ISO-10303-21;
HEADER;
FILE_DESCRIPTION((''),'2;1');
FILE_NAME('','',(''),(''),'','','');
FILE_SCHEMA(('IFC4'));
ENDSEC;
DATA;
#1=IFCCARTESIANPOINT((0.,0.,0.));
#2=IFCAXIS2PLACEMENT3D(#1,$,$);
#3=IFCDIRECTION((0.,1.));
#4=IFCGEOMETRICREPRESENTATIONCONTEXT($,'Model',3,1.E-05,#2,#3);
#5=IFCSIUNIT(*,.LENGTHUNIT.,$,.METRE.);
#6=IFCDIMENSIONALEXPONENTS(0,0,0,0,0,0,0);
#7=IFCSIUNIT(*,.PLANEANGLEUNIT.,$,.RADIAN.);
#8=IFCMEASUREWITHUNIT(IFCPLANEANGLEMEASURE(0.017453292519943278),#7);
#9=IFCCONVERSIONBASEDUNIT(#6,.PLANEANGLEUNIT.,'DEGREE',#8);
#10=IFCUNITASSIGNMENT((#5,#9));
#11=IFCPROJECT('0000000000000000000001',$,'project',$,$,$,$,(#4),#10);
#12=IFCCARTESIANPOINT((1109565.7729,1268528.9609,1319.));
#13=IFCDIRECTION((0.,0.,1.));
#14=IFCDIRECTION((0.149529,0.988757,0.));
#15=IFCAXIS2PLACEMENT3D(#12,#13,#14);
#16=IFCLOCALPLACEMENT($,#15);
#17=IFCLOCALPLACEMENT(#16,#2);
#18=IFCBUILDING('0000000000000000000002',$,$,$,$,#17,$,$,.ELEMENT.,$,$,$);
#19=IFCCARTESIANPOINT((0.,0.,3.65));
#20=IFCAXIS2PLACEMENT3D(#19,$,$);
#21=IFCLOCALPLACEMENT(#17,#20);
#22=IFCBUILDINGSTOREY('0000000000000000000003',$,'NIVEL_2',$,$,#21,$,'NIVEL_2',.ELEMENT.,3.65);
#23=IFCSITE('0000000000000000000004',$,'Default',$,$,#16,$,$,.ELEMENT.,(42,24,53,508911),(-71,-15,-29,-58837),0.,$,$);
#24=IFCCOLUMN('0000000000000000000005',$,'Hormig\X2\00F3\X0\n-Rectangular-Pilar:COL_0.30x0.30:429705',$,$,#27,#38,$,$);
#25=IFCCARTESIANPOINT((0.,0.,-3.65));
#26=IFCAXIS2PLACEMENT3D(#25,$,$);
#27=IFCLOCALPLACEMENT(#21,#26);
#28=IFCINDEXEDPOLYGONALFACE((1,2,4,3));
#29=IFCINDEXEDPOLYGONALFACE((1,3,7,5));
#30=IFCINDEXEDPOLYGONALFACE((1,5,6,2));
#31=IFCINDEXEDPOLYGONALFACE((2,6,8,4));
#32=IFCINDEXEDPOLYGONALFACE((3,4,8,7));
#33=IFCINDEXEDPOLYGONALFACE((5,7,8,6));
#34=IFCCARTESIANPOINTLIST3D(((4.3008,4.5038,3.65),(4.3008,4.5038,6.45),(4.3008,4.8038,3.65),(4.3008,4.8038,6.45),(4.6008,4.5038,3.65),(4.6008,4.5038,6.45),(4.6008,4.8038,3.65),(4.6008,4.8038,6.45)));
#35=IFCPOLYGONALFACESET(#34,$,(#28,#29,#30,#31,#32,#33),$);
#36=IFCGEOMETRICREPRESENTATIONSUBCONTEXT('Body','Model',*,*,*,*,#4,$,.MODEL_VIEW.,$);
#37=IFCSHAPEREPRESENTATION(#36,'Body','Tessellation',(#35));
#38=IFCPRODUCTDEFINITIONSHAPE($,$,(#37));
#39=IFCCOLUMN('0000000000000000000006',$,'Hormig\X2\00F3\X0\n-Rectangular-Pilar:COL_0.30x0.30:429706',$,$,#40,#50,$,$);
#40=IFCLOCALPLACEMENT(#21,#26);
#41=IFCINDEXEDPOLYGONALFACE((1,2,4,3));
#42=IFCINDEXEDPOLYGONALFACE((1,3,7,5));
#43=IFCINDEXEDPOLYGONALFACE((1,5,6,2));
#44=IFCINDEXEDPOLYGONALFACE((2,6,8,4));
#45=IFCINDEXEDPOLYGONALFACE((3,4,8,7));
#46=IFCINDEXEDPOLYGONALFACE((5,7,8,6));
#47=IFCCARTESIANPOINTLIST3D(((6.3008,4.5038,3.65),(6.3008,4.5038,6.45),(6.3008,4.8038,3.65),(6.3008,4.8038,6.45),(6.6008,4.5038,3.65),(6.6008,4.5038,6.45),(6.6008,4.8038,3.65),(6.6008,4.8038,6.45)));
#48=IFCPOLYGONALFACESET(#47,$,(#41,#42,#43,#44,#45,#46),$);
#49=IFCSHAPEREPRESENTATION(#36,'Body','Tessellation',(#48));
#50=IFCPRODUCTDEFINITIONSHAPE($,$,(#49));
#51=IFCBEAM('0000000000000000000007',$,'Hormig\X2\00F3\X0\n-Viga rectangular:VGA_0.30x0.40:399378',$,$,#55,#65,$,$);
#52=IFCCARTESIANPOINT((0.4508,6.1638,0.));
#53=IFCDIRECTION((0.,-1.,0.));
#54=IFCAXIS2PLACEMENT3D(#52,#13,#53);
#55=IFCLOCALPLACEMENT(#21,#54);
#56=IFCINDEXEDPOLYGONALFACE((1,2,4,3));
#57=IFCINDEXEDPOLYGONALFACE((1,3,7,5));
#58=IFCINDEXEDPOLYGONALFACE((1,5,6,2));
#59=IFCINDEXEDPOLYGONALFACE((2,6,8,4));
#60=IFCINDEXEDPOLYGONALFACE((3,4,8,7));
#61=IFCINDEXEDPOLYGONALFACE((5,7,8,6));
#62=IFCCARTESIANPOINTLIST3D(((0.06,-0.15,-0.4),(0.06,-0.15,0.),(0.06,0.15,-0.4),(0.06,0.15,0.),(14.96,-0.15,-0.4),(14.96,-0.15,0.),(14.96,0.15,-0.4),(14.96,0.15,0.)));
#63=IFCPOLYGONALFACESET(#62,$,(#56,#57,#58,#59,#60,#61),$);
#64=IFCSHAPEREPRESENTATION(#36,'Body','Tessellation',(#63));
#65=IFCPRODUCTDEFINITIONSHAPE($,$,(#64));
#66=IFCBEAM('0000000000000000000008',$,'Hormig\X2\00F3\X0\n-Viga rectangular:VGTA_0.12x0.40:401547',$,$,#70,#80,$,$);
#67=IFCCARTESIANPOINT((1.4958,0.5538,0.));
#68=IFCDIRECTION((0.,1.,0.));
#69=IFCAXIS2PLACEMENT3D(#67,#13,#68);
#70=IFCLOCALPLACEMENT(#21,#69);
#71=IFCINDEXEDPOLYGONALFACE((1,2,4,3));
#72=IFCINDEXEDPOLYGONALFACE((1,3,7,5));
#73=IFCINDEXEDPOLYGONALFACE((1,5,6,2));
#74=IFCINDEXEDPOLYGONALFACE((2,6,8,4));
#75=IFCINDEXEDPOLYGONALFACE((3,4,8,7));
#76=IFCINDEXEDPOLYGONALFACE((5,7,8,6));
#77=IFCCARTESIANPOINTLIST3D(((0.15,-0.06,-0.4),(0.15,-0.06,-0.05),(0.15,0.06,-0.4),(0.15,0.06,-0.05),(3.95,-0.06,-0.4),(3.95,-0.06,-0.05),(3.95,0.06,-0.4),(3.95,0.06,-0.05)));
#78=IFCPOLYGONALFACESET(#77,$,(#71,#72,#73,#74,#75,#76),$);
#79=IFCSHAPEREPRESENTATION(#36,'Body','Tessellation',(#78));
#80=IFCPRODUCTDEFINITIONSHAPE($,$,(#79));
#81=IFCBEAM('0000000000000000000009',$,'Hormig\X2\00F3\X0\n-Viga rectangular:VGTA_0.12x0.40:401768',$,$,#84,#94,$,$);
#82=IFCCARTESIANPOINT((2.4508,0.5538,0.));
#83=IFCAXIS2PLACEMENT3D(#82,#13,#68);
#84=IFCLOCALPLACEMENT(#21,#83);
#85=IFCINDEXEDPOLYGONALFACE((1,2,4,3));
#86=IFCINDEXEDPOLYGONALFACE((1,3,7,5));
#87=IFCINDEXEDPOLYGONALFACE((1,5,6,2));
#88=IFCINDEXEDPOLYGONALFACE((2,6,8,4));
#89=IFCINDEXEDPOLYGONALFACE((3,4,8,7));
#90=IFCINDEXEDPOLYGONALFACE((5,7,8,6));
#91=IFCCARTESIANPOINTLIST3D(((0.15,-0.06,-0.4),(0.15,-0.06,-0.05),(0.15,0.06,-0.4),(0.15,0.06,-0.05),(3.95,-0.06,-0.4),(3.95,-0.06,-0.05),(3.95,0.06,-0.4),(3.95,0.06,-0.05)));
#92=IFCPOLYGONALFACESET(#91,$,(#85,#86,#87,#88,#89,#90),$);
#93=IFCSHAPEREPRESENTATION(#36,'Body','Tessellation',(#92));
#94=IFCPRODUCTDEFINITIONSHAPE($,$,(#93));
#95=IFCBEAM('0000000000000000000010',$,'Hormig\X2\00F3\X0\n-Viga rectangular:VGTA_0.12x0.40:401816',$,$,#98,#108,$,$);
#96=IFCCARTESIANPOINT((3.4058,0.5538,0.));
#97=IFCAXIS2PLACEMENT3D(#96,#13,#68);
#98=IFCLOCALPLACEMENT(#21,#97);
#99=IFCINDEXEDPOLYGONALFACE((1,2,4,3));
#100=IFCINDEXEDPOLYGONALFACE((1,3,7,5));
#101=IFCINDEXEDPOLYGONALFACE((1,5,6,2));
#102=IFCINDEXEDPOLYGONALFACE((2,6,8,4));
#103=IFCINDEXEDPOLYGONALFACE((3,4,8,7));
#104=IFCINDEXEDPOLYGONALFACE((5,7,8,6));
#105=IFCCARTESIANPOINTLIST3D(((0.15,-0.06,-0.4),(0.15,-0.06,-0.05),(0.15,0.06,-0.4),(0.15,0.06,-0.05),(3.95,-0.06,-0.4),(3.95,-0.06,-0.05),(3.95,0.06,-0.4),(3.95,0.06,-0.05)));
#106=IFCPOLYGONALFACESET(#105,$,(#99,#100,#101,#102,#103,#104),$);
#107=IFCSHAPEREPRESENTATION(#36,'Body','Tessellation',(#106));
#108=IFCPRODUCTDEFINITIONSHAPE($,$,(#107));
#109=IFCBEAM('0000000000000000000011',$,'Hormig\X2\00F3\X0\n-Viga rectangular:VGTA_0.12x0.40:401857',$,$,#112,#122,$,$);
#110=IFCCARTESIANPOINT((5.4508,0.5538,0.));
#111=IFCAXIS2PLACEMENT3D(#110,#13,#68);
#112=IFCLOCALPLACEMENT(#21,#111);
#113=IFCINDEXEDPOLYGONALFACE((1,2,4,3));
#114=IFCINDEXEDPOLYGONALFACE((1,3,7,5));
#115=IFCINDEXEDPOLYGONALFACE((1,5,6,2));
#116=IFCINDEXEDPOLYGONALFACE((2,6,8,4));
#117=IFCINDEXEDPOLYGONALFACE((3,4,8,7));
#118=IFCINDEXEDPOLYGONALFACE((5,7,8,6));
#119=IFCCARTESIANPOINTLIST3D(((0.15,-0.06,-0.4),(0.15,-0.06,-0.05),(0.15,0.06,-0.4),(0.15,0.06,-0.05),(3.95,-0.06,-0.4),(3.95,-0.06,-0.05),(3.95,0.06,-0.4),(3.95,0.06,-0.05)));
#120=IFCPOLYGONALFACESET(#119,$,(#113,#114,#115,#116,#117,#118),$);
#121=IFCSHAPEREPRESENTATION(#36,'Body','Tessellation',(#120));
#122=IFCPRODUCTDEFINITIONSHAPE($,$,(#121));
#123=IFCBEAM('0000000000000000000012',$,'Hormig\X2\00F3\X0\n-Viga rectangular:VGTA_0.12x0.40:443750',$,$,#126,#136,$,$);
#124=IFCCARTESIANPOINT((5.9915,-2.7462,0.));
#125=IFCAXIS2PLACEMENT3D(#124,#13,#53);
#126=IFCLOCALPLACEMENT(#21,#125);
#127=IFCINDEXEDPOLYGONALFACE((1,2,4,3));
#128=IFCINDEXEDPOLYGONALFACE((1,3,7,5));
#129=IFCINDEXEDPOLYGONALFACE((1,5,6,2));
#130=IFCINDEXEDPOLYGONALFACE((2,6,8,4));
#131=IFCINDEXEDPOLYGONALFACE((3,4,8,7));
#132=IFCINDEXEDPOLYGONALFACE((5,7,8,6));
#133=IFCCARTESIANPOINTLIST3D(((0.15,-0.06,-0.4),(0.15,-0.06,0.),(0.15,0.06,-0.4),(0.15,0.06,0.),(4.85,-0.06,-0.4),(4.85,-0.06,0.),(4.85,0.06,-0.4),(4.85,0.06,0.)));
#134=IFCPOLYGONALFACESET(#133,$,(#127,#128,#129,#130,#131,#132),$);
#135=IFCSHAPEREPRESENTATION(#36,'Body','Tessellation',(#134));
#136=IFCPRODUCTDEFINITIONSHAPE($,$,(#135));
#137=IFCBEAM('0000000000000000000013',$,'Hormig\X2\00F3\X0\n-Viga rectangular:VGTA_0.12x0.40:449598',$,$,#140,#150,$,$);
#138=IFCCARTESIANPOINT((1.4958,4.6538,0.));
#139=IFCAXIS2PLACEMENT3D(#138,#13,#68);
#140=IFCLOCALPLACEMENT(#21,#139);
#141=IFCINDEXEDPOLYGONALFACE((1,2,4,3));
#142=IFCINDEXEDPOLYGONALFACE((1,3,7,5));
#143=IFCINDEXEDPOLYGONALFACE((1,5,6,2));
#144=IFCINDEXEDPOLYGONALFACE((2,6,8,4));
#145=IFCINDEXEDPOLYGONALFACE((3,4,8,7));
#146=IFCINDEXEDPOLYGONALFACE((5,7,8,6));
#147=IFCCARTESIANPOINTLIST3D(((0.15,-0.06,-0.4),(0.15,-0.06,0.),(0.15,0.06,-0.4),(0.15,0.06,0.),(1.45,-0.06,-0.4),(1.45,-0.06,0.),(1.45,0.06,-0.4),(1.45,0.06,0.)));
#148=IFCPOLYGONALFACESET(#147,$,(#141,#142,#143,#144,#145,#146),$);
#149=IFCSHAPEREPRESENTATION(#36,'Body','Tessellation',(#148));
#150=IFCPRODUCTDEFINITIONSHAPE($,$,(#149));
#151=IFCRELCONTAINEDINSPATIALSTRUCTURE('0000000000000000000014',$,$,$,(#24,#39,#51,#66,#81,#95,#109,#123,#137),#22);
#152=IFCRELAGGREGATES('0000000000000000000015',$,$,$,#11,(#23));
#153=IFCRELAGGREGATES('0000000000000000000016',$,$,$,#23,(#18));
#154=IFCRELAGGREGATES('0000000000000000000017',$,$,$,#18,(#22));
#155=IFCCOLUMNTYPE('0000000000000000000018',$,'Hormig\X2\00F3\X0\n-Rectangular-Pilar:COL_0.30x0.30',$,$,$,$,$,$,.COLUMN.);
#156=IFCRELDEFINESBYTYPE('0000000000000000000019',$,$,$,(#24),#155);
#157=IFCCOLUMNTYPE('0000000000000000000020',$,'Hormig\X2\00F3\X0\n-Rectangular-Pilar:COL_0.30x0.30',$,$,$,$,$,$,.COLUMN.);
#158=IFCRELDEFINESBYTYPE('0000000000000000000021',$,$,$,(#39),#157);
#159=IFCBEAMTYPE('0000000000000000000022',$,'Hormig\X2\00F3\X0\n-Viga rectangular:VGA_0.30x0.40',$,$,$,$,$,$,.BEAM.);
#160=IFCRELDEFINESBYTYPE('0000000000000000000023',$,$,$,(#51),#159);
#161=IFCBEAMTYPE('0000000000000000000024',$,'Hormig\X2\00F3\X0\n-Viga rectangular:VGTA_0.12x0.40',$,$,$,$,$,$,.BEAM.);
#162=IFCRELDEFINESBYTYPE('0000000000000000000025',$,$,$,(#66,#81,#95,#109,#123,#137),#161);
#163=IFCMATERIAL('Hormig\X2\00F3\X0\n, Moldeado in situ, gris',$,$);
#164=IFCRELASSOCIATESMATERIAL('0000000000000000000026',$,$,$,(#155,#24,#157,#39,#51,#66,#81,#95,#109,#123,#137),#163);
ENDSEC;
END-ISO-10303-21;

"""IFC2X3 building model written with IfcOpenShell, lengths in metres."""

from ifc_helpers import new_model, entity, si_unit, converted_unit, direction, frame, frame_2d, origin, origin_2d_with_axis, place, context, subcontext, project, spatial, rectangle, extrude, source, transform, mapped, material, type_object, type_shapes, element, save


model = new_model("IFC2X3")

# Units and contexts
model_context = context("Model", 3, precision=1e-05, world=origin(), true_north=direction((0.0, 1.0)))
body_context = subcontext(model_context, "Body", "Model", "MODEL_VIEW")
ifc_project = project(units=[si_unit("LENGTHUNIT", "METRE"), converted_unit("PLANEANGLEUNIT", "DEGREE", entity("IfcPlaneAngleMeasure", 0.017453292519943278), si_unit("PLANEANGLEUNIT", "RADIAN"), dimensions=[0, 0, 0, 0, 0, 0, 0])], contexts=[model_context])

# Site, building, storey
site_placement = place(None, frame((1109565.7729, 1268528.9609, 1319.0), z_axis=(0.0, 0.0, 1.0), x_axis=(0.149529, 0.988757, 0.0)))
site = spatial("IfcSite", under=ifc_project, at=site_placement, Name="Default", CompositionType="ELEMENT", RefLatitude=(42, 24, 53, 508911), RefLongitude=(-71, -15, -29, -58837), RefElevation=0.0)
building_placement = place(site_placement, origin())
building = spatial("IfcBuilding", under=site, at=building_placement, CompositionType="ELEMENT")
storey_placement = place(building_placement, frame((0.0, 0.0, 3.65)))
storey = spatial("IfcBuildingStorey", under=building, at=storey_placement, Name="NIVEL_2", LongName="NIVEL_2", CompositionType="ELEMENT", Elevation=3.65)

# Columns
ifc_material_1 = material(Name="Hormigón, Moldeado in situ, gris")
column_type_1 = type_object("IfcColumnType", Name="Hormigón-Rectangular-Pilar:COL_0.30x0.30", PredefinedType="COLUMN", material=ifc_material_1)
shared_shape_1 = source(origin(), body_context, "Body", "SweptSolid", [
    extrude(rectangle(XDim=0.3, YDim=0.3, at=origin_2d_with_axis()), frame((4.4508, 4.6538, 3.65)), (0.0, 0.0, 1.0), 2.8),
])
type_shapes(column_type_1, [shared_shape_1])
column_1_placement = place(storey_placement, frame((0.0, 0.0, -3.65)))
element("IfcColumn", 1, at=column_1_placement, inside=storey, type_object=column_type_1, material=ifc_material_1, Name="Hormigón-Rectangular-Pilar:COL_0.30x0.30:429705", context=body_context, shape_type="MappedRepresentation", body=[
    mapped(shared_shape_1, transform((0.0, 0.0, 0.0), scale=1.0)),
])
column_type_2 = type_object("IfcColumnType", Name="Hormigón-Rectangular-Pilar:COL_0.30x0.30", PredefinedType="COLUMN", material=ifc_material_1)
shared_shape_2 = source(origin(), body_context, "Body", "SweptSolid", [
    extrude(rectangle(XDim=0.3, YDim=0.3, at=frame_2d((0.0, 0.0), x_axis=(1.0, 0.0))), frame((6.4508, 4.6538, 3.65)), (0.0, 0.0, 1.0), 2.8),
])
type_shapes(column_type_2, [shared_shape_2])
column_2_placement = place(storey_placement, frame((0.0, 0.0, -3.65)))
element("IfcColumn", 2, at=column_2_placement, inside=storey, type_object=column_type_2, material=ifc_material_1, Name="Hormigón-Rectangular-Pilar:COL_0.30x0.30:429706", context=body_context, shape_type="MappedRepresentation", body=[
    mapped(shared_shape_2, transform((0.0, 0.0, 0.0), scale=1.0)),
])

# Beams
beam_type_1 = type_object("IfcBeamType", Name="Hormigón-Viga rectangular:VGA_0.30x0.40", PredefinedType="BEAM")
beam_1_placement = place(storey_placement, frame((0.4508, 6.1638, 0.0), z_axis=(0.0, 0.0, 1.0), x_axis=(0.0, -1.0, 0.0)))
element("IfcBeam", 3, at=beam_1_placement, inside=storey, type_object=beam_type_1, material=ifc_material_1, Name="Hormigón-Viga rectangular:VGA_0.30x0.40:399378", context=body_context, shape_type="SweptSolid", body=[
    extrude(rectangle(XDim=0.4, YDim=0.3, at=frame_2d((0.0, 0.0), x_axis=(1.0, 0.0))), frame((0.06, 0.0, -0.2), z_axis=(1.0, 0.0, 0.0), x_axis=(0.0, 0.0, -1.0)), (0.0, 0.0, 1.0), 14.9),
])
beam_type_2 = type_object("IfcBeamType", Name="Hormigón-Viga rectangular:VGTA_0.12x0.40", PredefinedType="BEAM")
beam_2_placement = place(storey_placement, frame((1.4958, 0.5538, 0.0), z_axis=(0.0, 0.0, 1.0), x_axis=(0.0, 1.0, 0.0)))
element("IfcBeam", 4, at=beam_2_placement, inside=storey, type_object=beam_type_2, material=ifc_material_1, Name="Hormigón-Viga rectangular:VGTA_0.12x0.40:401547", context=body_context, shape_type="SweptSolid", body=[
    extrude(rectangle(XDim=0.35, YDim=0.12, at=frame_2d((0.0, 0.0), x_axis=(1.0, 0.0))), frame((0.15, 0.0, -0.225), z_axis=(1.0, 0.0, 0.0), x_axis=(0.0, 0.0, -1.0)), (0.0, 0.0, 1.0), 3.8),
])
beam_3_placement = place(storey_placement, frame((2.4508, 0.5538, 0.0), z_axis=(0.0, 0.0, 1.0), x_axis=(0.0, 1.0, 0.0)))
element("IfcBeam", 5, at=beam_3_placement, inside=storey, type_object=beam_type_2, material=ifc_material_1, Name="Hormigón-Viga rectangular:VGTA_0.12x0.40:401768", context=body_context, shape_type="SweptSolid", body=[
    extrude(rectangle(XDim=0.35, YDim=0.12, at=frame_2d((0.0, 0.0), x_axis=(1.0, 0.0))), frame((0.15, 0.0, -0.225), z_axis=(1.0, 0.0, 0.0), x_axis=(0.0, 0.0, -1.0)), (0.0, 0.0, 1.0), 3.8),
])
beam_4_placement = place(storey_placement, frame((3.4058, 0.5538, 0.0), z_axis=(0.0, 0.0, 1.0), x_axis=(0.0, 1.0, 0.0)))
element("IfcBeam", 6, at=beam_4_placement, inside=storey, type_object=beam_type_2, material=ifc_material_1, Name="Hormigón-Viga rectangular:VGTA_0.12x0.40:401816", context=body_context, shape_type="SweptSolid", body=[
    extrude(rectangle(XDim=0.35, YDim=0.12, at=frame_2d((0.0, 0.0), x_axis=(1.0, 0.0))), frame((0.15, 0.0, -0.225), z_axis=(1.0, 0.0, 0.0), x_axis=(0.0, 0.0, -1.0)), (0.0, 0.0, 1.0), 3.8),
])
beam_5_placement = place(storey_placement, frame((5.4508, 0.5538, 0.0), z_axis=(0.0, 0.0, 1.0), x_axis=(0.0, 1.0, 0.0)))
element("IfcBeam", 7, at=beam_5_placement, inside=storey, type_object=beam_type_2, material=ifc_material_1, Name="Hormigón-Viga rectangular:VGTA_0.12x0.40:401857", context=body_context, shape_type="SweptSolid", body=[
    extrude(rectangle(XDim=0.35, YDim=0.12, at=frame_2d((0.0, 0.0), x_axis=(1.0, 0.0))), frame((0.15, 0.0, -0.225), z_axis=(1.0, 0.0, 0.0), x_axis=(0.0, 0.0, -1.0)), (0.0, 0.0, 1.0), 3.8),
])
beam_6_placement = place(storey_placement, frame((5.9915, -2.7462, 0.0), z_axis=(0.0, 0.0, 1.0), x_axis=(0.0, -1.0, 0.0)))
element("IfcBeam", 8, at=beam_6_placement, inside=storey, type_object=beam_type_2, material=ifc_material_1, Name="Hormigón-Viga rectangular:VGTA_0.12x0.40:443750", context=body_context, shape_type="SweptSolid", body=[
    extrude(rectangle(XDim=0.4, YDim=0.12, at=frame_2d((0.0, 0.0), x_axis=(1.0, 0.0))), frame((0.15, 0.0, -0.2), z_axis=(1.0, 0.0, 0.0), x_axis=(0.0, 0.0, -1.0)), (0.0, 0.0, 1.0), 4.7),
])
beam_7_placement = place(storey_placement, frame((1.4958, 4.6538, 0.0), z_axis=(0.0, 0.0, 1.0), x_axis=(0.0, 1.0, 0.0)))
element("IfcBeam", 9, at=beam_7_placement, inside=storey, type_object=beam_type_2, material=ifc_material_1, Name="Hormigón-Viga rectangular:VGTA_0.12x0.40:449598", context=body_context, shape_type="SweptSolid", body=[
    extrude(rectangle(XDim=0.4, YDim=0.12, at=origin_2d_with_axis()), frame((0.15, 0.0, -0.2), z_axis=(1.0, 0.0, 0.0), x_axis=(0.0, 0.0, -1.0)), (0.0, 0.0, 1.0), 1.3),
])

save(model, "model.ifc")
